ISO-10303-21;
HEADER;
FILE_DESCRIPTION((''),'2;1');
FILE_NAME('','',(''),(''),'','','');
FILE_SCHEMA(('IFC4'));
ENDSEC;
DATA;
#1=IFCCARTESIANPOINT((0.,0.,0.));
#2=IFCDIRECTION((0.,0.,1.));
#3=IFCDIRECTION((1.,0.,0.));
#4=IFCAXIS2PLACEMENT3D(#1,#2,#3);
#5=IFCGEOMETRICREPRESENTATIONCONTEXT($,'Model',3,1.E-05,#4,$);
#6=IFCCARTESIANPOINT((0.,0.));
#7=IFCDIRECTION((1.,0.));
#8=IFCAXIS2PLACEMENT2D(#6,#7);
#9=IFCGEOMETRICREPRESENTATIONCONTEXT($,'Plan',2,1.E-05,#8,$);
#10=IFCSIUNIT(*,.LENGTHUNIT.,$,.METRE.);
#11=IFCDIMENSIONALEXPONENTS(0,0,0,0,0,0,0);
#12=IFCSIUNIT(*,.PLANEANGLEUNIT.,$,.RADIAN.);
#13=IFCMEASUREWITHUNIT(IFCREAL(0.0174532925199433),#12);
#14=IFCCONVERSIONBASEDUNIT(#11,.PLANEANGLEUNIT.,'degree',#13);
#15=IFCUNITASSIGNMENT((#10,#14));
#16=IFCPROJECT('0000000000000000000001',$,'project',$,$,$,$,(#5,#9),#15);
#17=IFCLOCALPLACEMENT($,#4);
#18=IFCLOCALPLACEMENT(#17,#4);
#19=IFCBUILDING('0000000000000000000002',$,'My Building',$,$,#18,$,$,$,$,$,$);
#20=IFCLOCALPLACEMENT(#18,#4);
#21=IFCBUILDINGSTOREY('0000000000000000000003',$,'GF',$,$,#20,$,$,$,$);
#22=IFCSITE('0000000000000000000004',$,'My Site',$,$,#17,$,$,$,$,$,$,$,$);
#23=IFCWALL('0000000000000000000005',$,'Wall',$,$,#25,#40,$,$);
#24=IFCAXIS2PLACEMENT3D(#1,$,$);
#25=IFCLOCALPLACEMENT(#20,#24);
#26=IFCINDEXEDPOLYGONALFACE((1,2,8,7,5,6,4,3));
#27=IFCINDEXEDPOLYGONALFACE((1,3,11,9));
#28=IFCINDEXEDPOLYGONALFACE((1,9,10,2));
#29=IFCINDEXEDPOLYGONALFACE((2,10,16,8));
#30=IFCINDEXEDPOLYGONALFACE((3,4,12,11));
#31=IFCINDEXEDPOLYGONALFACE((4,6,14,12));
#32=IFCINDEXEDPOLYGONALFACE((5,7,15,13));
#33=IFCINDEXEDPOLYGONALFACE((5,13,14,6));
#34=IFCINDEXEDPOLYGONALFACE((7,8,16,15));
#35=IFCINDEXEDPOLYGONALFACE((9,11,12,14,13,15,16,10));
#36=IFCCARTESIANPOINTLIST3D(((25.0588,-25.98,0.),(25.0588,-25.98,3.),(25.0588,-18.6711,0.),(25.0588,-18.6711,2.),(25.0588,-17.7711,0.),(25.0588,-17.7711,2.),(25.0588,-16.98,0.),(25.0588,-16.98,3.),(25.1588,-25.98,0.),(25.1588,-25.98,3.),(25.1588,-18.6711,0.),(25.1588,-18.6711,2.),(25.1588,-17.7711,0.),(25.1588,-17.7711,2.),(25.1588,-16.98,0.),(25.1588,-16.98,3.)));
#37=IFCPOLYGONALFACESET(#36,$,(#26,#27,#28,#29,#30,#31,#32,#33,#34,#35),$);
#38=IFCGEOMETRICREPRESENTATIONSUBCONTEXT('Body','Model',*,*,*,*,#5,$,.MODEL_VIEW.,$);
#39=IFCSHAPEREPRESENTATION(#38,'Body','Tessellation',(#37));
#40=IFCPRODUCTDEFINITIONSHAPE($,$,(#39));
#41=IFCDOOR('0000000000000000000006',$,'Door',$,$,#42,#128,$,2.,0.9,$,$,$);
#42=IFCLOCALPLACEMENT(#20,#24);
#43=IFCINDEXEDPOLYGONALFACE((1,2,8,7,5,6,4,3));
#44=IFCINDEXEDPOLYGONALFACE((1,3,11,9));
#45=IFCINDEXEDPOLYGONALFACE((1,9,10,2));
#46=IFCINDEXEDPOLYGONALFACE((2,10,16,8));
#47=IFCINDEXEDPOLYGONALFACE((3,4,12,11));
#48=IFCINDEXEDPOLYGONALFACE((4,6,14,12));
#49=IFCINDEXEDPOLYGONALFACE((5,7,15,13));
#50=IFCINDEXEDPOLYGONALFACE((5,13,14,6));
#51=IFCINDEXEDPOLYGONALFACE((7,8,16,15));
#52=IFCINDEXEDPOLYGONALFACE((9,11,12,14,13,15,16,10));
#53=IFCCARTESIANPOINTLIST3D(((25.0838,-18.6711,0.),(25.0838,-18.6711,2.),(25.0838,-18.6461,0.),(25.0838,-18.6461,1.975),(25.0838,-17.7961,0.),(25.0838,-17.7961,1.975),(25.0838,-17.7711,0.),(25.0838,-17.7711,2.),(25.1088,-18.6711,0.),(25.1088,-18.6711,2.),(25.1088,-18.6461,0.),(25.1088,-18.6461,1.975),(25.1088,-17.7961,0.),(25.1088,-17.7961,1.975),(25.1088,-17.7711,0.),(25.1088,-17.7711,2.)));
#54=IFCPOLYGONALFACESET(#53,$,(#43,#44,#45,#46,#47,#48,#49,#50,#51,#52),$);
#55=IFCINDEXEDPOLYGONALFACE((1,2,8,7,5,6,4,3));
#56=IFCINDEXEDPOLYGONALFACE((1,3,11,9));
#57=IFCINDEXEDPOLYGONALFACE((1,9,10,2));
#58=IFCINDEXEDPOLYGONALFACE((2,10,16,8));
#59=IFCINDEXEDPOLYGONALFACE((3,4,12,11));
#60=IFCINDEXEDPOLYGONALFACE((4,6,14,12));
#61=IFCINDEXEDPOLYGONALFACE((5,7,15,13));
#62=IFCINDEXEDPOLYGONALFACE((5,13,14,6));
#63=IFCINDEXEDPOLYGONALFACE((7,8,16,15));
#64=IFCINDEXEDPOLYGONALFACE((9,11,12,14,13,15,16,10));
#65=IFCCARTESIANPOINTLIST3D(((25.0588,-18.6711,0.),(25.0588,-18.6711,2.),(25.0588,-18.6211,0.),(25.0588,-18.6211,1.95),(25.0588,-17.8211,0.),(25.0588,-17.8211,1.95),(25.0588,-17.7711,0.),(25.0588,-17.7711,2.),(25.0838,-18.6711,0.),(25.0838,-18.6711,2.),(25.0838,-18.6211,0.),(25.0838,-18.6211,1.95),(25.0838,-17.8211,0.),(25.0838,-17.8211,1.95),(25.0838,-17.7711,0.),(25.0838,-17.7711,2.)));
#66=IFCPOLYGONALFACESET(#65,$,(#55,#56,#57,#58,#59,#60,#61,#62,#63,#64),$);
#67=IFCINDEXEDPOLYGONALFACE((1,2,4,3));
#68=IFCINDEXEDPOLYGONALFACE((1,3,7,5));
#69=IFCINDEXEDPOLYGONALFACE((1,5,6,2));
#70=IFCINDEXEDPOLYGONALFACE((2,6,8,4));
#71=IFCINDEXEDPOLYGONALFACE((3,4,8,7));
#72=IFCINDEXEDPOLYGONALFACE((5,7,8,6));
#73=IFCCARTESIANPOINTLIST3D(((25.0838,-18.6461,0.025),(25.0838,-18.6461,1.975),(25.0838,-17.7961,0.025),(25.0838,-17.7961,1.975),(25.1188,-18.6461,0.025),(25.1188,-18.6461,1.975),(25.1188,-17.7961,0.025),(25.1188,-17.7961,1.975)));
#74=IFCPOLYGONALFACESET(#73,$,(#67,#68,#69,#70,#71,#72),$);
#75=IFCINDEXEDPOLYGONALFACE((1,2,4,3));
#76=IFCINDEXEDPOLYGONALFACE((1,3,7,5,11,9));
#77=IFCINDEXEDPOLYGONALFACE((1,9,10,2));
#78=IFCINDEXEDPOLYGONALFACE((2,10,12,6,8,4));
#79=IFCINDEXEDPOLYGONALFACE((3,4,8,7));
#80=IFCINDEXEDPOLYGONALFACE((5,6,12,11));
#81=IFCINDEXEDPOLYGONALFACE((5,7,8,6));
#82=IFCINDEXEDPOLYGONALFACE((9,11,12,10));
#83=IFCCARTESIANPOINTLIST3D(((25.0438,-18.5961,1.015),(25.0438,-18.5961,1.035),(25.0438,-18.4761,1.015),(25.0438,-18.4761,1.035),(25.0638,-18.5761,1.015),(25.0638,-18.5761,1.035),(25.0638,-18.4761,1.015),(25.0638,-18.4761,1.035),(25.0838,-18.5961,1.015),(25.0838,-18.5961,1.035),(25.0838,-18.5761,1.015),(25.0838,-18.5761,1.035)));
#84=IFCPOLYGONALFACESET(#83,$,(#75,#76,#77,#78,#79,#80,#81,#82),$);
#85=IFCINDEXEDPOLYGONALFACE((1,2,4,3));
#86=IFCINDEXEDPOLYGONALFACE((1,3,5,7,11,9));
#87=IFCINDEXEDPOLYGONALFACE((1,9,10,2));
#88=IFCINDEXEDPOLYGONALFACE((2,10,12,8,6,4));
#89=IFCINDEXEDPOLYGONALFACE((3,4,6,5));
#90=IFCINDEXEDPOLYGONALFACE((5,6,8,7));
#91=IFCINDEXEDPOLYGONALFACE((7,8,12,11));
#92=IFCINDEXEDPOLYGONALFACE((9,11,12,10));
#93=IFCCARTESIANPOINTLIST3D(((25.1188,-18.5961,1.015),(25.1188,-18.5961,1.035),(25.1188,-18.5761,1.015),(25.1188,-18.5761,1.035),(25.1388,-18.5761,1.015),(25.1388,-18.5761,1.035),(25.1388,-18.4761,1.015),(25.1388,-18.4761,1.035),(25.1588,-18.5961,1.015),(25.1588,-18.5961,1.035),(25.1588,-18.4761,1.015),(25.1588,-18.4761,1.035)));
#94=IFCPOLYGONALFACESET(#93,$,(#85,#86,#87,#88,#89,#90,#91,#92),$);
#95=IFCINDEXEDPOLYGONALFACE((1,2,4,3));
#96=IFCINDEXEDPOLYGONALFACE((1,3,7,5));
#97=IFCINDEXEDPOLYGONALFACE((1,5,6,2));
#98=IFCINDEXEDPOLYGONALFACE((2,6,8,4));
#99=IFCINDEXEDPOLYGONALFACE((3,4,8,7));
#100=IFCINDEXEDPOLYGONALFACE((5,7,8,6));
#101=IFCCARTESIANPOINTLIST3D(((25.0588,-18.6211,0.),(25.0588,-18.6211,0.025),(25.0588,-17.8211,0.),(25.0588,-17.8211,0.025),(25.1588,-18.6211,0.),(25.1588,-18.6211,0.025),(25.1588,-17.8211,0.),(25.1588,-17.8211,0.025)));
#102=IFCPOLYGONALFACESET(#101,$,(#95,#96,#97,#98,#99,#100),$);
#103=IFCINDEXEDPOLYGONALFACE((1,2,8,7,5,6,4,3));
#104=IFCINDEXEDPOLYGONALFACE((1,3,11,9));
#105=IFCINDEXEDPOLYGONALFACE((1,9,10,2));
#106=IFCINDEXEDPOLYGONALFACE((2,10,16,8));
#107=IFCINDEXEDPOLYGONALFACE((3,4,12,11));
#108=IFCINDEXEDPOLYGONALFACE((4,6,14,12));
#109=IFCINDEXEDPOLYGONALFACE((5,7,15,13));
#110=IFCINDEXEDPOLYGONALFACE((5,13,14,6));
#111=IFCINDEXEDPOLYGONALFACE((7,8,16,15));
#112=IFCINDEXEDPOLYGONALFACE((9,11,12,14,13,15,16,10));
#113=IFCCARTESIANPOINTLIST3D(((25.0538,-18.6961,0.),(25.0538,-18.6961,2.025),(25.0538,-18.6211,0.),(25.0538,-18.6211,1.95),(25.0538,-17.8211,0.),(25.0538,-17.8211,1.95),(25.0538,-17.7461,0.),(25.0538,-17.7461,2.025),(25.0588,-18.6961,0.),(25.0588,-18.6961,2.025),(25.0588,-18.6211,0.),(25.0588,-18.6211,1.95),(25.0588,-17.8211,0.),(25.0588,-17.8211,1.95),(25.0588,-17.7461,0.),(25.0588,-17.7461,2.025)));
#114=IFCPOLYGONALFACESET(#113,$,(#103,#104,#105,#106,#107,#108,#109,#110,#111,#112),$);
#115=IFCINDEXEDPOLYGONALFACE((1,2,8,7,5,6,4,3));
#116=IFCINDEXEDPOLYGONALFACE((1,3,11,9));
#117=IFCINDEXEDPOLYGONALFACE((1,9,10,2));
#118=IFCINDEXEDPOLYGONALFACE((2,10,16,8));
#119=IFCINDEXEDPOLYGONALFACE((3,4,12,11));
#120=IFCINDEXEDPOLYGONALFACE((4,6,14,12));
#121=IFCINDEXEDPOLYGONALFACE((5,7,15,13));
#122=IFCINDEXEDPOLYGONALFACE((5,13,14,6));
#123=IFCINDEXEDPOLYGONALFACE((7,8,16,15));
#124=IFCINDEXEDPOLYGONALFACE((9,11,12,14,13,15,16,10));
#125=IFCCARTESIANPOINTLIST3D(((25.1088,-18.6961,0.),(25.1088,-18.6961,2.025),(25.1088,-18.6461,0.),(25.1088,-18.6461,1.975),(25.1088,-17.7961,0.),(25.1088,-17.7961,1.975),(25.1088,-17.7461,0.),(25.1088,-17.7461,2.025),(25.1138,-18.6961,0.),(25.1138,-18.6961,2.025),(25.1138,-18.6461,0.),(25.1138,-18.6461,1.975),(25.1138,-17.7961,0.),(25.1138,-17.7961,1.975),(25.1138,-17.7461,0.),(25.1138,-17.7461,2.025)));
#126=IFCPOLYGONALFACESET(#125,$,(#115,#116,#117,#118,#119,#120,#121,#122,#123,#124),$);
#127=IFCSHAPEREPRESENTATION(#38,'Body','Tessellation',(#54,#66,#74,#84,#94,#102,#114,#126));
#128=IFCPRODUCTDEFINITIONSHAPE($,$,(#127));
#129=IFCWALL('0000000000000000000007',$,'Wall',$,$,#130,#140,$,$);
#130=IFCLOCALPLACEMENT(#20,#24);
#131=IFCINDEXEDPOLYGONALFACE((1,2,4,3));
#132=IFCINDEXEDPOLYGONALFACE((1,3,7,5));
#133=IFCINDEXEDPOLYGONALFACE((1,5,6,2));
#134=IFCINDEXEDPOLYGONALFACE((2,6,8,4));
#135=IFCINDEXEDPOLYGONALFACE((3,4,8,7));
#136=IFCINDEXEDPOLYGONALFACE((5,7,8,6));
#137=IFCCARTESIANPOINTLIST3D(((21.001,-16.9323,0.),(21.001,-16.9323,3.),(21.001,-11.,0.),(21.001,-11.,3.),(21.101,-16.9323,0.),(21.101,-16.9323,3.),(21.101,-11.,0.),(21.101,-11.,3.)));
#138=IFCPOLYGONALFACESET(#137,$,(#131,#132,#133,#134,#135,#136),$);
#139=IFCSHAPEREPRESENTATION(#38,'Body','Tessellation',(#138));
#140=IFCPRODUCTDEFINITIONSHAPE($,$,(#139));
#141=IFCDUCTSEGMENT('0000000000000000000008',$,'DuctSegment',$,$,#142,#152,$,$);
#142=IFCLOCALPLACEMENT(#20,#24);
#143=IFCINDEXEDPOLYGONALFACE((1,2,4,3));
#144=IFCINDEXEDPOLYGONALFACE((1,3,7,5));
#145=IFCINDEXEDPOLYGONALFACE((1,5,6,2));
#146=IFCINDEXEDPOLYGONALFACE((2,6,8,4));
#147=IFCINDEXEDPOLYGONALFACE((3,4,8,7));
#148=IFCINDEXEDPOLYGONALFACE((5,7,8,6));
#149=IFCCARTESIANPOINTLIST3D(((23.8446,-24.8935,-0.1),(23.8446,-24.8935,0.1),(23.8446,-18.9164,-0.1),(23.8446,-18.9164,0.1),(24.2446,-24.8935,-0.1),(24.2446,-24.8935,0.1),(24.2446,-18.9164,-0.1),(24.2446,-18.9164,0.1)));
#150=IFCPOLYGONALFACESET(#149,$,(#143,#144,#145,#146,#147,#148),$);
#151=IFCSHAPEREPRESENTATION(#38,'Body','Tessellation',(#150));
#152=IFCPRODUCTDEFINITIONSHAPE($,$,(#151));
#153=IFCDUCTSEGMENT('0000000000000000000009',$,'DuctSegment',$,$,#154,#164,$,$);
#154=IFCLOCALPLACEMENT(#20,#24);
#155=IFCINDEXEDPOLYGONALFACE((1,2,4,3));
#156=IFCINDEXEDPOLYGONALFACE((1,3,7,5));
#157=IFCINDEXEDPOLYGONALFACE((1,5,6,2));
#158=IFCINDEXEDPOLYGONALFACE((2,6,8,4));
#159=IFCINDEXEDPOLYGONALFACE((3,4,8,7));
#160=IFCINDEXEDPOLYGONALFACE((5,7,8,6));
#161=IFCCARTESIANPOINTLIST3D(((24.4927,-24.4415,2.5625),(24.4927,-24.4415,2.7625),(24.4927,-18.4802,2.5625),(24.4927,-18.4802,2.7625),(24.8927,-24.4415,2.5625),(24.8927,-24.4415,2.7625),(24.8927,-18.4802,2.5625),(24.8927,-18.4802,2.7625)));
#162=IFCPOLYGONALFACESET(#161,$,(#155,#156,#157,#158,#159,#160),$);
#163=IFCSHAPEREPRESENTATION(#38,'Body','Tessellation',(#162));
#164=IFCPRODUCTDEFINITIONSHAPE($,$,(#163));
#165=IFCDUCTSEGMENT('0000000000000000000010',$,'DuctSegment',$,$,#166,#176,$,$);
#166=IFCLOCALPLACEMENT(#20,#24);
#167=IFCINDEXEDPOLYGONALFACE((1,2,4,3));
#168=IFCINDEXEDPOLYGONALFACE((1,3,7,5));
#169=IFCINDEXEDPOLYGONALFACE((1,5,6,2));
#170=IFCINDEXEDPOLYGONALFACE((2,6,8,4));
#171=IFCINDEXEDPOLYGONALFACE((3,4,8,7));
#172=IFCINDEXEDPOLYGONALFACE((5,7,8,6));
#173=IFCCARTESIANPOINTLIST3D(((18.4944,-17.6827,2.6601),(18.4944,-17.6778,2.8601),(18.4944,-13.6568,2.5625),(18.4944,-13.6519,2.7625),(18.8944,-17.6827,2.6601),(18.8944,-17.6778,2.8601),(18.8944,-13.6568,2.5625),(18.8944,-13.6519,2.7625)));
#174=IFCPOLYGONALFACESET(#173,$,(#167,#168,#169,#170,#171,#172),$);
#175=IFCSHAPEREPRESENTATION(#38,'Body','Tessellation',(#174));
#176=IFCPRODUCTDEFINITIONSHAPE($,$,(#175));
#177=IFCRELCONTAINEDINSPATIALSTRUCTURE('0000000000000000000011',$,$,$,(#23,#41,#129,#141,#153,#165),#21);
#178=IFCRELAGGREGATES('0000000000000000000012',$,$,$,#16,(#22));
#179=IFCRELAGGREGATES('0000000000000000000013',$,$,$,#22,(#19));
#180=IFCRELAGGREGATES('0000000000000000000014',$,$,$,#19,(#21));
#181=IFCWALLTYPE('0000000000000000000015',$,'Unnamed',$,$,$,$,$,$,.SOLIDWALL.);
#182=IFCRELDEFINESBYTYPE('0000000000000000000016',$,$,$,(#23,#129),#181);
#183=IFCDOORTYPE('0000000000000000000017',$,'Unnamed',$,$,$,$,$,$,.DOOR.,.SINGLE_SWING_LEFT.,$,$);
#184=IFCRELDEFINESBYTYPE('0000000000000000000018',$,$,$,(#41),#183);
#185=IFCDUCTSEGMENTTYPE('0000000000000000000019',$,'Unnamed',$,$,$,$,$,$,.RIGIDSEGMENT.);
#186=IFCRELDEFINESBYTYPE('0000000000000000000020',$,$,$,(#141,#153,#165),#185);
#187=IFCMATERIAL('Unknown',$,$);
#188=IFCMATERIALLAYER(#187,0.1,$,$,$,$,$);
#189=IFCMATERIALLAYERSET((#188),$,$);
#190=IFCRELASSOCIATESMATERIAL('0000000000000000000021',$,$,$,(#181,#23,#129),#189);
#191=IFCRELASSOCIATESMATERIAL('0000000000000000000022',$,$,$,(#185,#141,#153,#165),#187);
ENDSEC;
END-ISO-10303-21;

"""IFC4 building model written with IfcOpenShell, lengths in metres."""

from ifc_helpers import new_model, entity, si_unit, converted_unit, frame, origin_with_axes, origin_2d_with_axis, place, context, subcontext, project, spatial, line, indexed_curve, rectangle, outline, extrude, shape, source, transform, mapped, material, layer, layer_set, layer_usage, material_profile, profile_set, profile_usage, type_object, type_shapes, element, fill, save


model = new_model("IFC4")

# Units and contexts
model_context = context("Model", 3, precision=1e-05, world=origin_with_axes())
plan_context = context("Plan", 2, precision=1e-05, world=origin_2d_with_axis())
body_context_1 = subcontext(model_context, "Body", "Model", "MODEL_VIEW")
body_context_2 = subcontext(plan_context, "Body", "Plan", "PLAN_VIEW")
ifc_project = project(units=[si_unit("LENGTHUNIT", "METRE"), converted_unit("PLANEANGLEUNIT", "degree", entity("IfcReal", 0.0174532925199433), si_unit("PLANEANGLEUNIT", "RADIAN"), dimensions=[0, 0, 0, 0, 0, 0, 0])], contexts=[model_context, plan_context])

# Site, building, storey
site_placement = place(None, origin_with_axes())
site = spatial("IfcSite", under=ifc_project, at=site_placement, Name="My Site")
building_placement = place(site_placement, origin_with_axes())
building = spatial("IfcBuilding", under=site, at=building_placement, Name="My Building")
storey_placement = place(building_placement, origin_with_axes())
storey = spatial("IfcBuildingStorey", under=building, at=storey_placement, Name="GF")

# Shared definitions
ifc_material = material(Name="Unknown")
ifc_layer = layer(ifc_material, 0.1)
ifc_layer_set = layer_set([ifc_layer])
wall_type = type_object("IfcWallType", Name="Unnamed", PredefinedType="SOLIDWALL", material=ifc_layer_set)

# Shared definitions
shared_shape_1 = source(origin_with_axes(), body_context_1, "Body", "SweptSolid", [
    extrude(outline(indexed_curve([(0.0, 0.0), (0.9, 0.0), (0.9, 2.0), (0.0, 2.0)], segments=[line(1, 2, 3, 4, 1)])), frame((0.0, -0.6, 0.0), z_axis=(0.0, -1.0, 0.0), x_axis=(1.0, 0.0, 0.0)), (0.0, 0.0, -1.0), 1.2),
])
door_type = type_object("IfcDoorType", Name="Unnamed", OperationType="SINGLE_SWING_LEFT", PredefinedType="DOOR")
shared_shape_2 = source(origin_with_axes(), body_context_1, "Body", "SweptSolid", [
    extrude(outline(indexed_curve([(0.0, 0.0), (0.0, 2.0), (0.9, 2.0), (0.9, 0.0), (0.875, 0.0), (0.875, 1.975), (0.025, 1.975), (0.025, 0.0)], segments=[line(1, 2, 3, 4, 5, 6, 7, 8, 1)])), frame((0.0, 0.025, 0.0), z_axis=(0.0, -1.0, 0.0), x_axis=(1.0, 0.0, 0.0)), (0.0, 0.0, -1.0), 0.025),
    extrude(outline(indexed_curve([(0.0, 0.0), (0.0, 2.0), (0.9, 2.0), (0.9, 0.0), (0.85, 0.0), (0.85, 1.95), (0.05, 1.95), (0.05, 0.0)], segments=[line(1, 2, 3, 4, 5, 6, 7, 8, 1)])), frame((0.0, 0.0, 0.0), z_axis=(0.0, -1.0, 0.0), x_axis=(1.0, 0.0, 0.0)), (0.0, 0.0, -1.0), 0.025),
    extrude(outline(indexed_curve([(0.0, 0.0), (0.85, 0.0), (0.85, 0.035), (0.0, 0.035)], segments=[line(1, 2, 3, 4, 1)])), frame((0.025, 0.025, 0.025), z_axis=(0.0, 0.0, 1.0), x_axis=(1.0, 0.0, 0.0)), (0.0, 0.0, 1.0), 1.95),
    extrude(outline(indexed_curve([(0.0, 0.0), (0.0, -0.04), (-0.12, -0.04), (-0.12, -0.02), (-0.02, -0.02), (-0.02, 0.0)], segments=[line(1, 2, 3, 4, 5, 6, 1)])), frame((0.825, 0.025, 1.015), z_axis=(0.0, 0.0, 1.0), x_axis=(1.0, 0.0, 0.0)), (0.0, 0.0, 1.0), 0.02),
    extrude(outline(indexed_curve([(0.0, 0.0), (0.0, 0.04), (-0.12, 0.04), (-0.12, 0.02), (-0.02, 0.02), (-0.02, 0.0)], segments=[line(1, 2, 3, 4, 5, 6, 1)])), frame((0.825, 0.06, 1.015), z_axis=(0.0, 0.0, 1.0), x_axis=(1.0, 0.0, 0.0)), (0.0, 0.0, 1.0), 0.02),
    extrude(outline(indexed_curve([(0.0, 0.0), (0.8, 0.0), (0.8, 0.1), (0.0, 0.1)], segments=[line(1, 2, 3, 4, 1)])), frame((0.05, 0.0, 0.0), z_axis=(0.0, 0.0, 1.0), x_axis=(1.0, 0.0, 0.0)), (0.0, 0.0, 1.0), 0.025),
    extrude(outline(indexed_curve([(0.0, 0.0), (0.0, 2.025), (0.95, 2.025), (0.95, 0.0), (0.875, 0.0), (0.875, 1.95), (0.075, 1.95), (0.075, 0.0)], segments=[line(1, 2, 3, 4, 5, 6, 7, 8, 1)])), frame((-0.025, -0.005, 0.0), z_axis=(0.0, -1.0, 0.0), x_axis=(1.0, 0.0, 0.0)), (0.0, 0.0, -1.0), 0.005),
    extrude(outline(indexed_curve([(0.0, 0.0), (0.0, 2.025), (0.95, 2.025), (0.95, 0.0), (0.9, 0.0), (0.9, 1.975), (0.05, 1.975), (0.05, 0.0)], segments=[line(1, 2, 3, 4, 5, 6, 7, 8, 1)])), frame((-0.025, 0.05, 0.0), z_axis=(0.0, -1.0, 0.0), x_axis=(1.0, 0.0, 0.0)), (0.0, 0.0, -1.0), 0.005),
])
shared_shape_3 = source(origin_with_axes(), body_context_2, "Body", "Curve2D", [
    entity("IfcIndexedPolyCurve", entity("IfcCartesianPointList2D", [[0.0, 0.0], [0.0, 0.05], [0.025, 0.05], [0.025, 0.025], [0.05, 0.025], [0.05, 0.0]]), [entity("IfcLineIndex", [1, 2, 3, 4, 5, 6, 1])]),
    entity("IfcIndexedPolyCurve", entity("IfcCartesianPointList2D", [[0.9, 0.0], [0.9, 0.05], [0.875, 0.05], [0.875, 0.025], [0.85, 0.025], [0.85, 0.0]]), [entity("IfcLineIndex", [1, 2, 3, 4, 5, 6, 1])]),
    entity("IfcTrimmedCurve", entity("IfcEllipse", entity("IfcAxis2Placement2D", entity("IfcCartesianPoint", [0.06, 0.05]), entity("IfcDirection", [1.0, 0.0])), 0.815, 0.85), [entity("IfcCartesianPoint", [0.875, 0.05])], [entity("IfcCartesianPoint", [0.06, 0.9])], True, "CARTESIAN"),
    entity("IfcIndexedPolyCurve", entity("IfcCartesianPointList2D", [[0.025, 0.05], [0.06, 0.05], [0.06, 0.9], [0.025, 0.9]]), [entity("IfcLineIndex", [1, 2, 3, 4, 1])]),
])
type_shapes(door_type, [shared_shape_2, shared_shape_3])

# Wall, opening, door
ifc_layer_usage_1 = layer_usage(ifc_layer_set, "AXIS2", "POSITIVE", 0.0)
wall_1_placement = place(storey_placement, frame((25.0588, -16.98, 0.0), z_axis=(0.0, 0.0, 1.0), x_axis=(0.0, -1.0, 0.0)))
wall_1 = element("IfcWall", 1, at=wall_1_placement, inside=storey, type_object=wall_type, material=ifc_layer_usage_1, Name="Wall", context=body_context_1, shape_type="SweptSolid", body=[
    extrude(outline(indexed_curve([(0.0, 0.0), (0.0, 0.1), (9.0, 0.1), (9.0, 0.0)], segments=[line(1, 2, 3, 4, 1)])), origin_with_axes(), (0.0, 0.0, 1.0), 3.0),
])
opening_1_placement = place(wall_1_placement, frame((0.7911, 0.0, 0.0), z_axis=(0.0, 0.0, 1.0), x_axis=(1.0, 0.0, 0.0)))
opening_1 = element("IfcOpeningElement", 2, at=opening_1_placement, cuts=wall_1, PredefinedType="OPENING", context=body_context_1, shape_type="MappedRepresentation", body=[
    mapped(shared_shape_1, transform((0.0, 0.0, 0.0), x_axis=(1.0, 0.0, 0.0), y_axis=(0.0, 1.0, 0.0), z_axis=(0.0, 0.0, 1.0), scale=1.0)),
])
door_1_placement = place(opening_1_placement, frame((0.0, 0.0, 0.0), z_axis=(0.0, 0.0, 1.0), x_axis=(1.0, 0.0, 0.0)))
door_1 = element("IfcDoor", 3, at=door_1_placement, inside=storey, type_object=door_type, Name="Door", OverallHeight=2.0, OverallWidth=0.9, shapes=[
    shape(body_context_1, "Body", "MappedRepresentation", [mapped(shared_shape_2, transform((0.0, 0.0, 0.0), x_axis=(1.0, 0.0, 0.0), y_axis=(0.0, 1.0, 0.0), z_axis=(0.0, 0.0, 1.0), scale=1.0))]),
    shape(body_context_2, "Body", "MappedRepresentation", [mapped(shared_shape_3, transform((0.0, 0.0, 0.0), x_axis=(1.0, 0.0, 0.0), y_axis=(0.0, 1.0, 0.0), z_axis=(0.0, 0.0, 1.0), scale=1.0))]),
])
fill(opening_1, door_1)

# Wall
ifc_layer_usage_2 = layer_usage(ifc_layer_set, "AXIS2", "POSITIVE", 0.0)
wall_2_placement = place(storey_placement, frame((21.101, -16.9323, 0.0), z_axis=(0.0, 0.0, 1.0), x_axis=(0.0, 1.0, 0.0)))
element("IfcWall", 4, at=wall_2_placement, inside=storey, type_object=wall_type, material=ifc_layer_usage_2, Name="Wall", context=body_context_1, shape_type="SweptSolid", body=[
    extrude(outline(indexed_curve([(0.0, 0.0), (0.0, 0.1), (5.9323, 0.1), (5.9323, 0.0)], segments=[line(1, 2, 3, 4, 1)])), origin_with_axes(), (0.0, 0.0, 1.0), 3.0),
])

# Duct segments
ifc_material_profile_1 = material_profile(ifc_material, rectangle(XDim=0.4, YDim=0.2))
ifc_profile_set_1 = profile_set([ifc_material_profile_1])
ifc_profile_usage_1 = profile_usage(ifc_profile_set_1, cardinal=5)
duct_segment_type = type_object("IfcDuctSegmentType", Name="Unnamed", PredefinedType="RIGIDSEGMENT", material=ifc_profile_set_1)
duct_segment_1_placement = place(storey_placement, frame((24.0446, -18.9164, 0.0), z_axis=(0.0, -1.0, 0.0), x_axis=(1.0, 0.0, 0.0)))
element("IfcDuctSegment", 5, at=duct_segment_1_placement, inside=storey, type_object=duct_segment_type, material=ifc_profile_usage_1, Name="DuctSegment", context=body_context_1, shape_type="SweptSolid", body=[
    extrude(rectangle(XDim=0.4, YDim=0.2), origin_with_axes(), (0.0, 0.0, 1.0), 5.9771),
])
ifc_profile_usage_2 = profile_usage(ifc_profile_set_1, cardinal=5)
duct_segment_2_placement = place(storey_placement, frame((24.6927, -18.4802, 2.6625), z_axis=(0.0, -1.0, 0.0), x_axis=(1.0, 0.0, 0.0)))
element("IfcDuctSegment", 6, at=duct_segment_2_placement, inside=storey, type_object=duct_segment_type, material=ifc_profile_usage_2, Name="DuctSegment", context=body_context_1, shape_type="SweptSolid", body=[
    extrude(rectangle(XDim=0.4, YDim=0.2), origin_with_axes(), (0.0, 0.0, 1.0), 5.9613),
])
ifc_profile_usage_3 = profile_usage(ifc_profile_set_1, cardinal=5)
duct_segment_3_placement = place(storey_placement, frame((18.6944, -17.6802, 2.7601), z_axis=(0.0, 0.999706, -0.02423), x_axis=(-1.0, 0.0, 0.0)))
element("IfcDuctSegment", 7, at=duct_segment_3_placement, inside=storey, type_object=duct_segment_type, material=ifc_profile_usage_3, Name="DuctSegment", context=body_context_1, shape_type="SweptSolid", body=[
    extrude(rectangle(XDim=0.4, YDim=0.2), origin_with_axes(), (0.0, 0.0, 1.0), 4.0271),
])

save(model, "model.ifc")
